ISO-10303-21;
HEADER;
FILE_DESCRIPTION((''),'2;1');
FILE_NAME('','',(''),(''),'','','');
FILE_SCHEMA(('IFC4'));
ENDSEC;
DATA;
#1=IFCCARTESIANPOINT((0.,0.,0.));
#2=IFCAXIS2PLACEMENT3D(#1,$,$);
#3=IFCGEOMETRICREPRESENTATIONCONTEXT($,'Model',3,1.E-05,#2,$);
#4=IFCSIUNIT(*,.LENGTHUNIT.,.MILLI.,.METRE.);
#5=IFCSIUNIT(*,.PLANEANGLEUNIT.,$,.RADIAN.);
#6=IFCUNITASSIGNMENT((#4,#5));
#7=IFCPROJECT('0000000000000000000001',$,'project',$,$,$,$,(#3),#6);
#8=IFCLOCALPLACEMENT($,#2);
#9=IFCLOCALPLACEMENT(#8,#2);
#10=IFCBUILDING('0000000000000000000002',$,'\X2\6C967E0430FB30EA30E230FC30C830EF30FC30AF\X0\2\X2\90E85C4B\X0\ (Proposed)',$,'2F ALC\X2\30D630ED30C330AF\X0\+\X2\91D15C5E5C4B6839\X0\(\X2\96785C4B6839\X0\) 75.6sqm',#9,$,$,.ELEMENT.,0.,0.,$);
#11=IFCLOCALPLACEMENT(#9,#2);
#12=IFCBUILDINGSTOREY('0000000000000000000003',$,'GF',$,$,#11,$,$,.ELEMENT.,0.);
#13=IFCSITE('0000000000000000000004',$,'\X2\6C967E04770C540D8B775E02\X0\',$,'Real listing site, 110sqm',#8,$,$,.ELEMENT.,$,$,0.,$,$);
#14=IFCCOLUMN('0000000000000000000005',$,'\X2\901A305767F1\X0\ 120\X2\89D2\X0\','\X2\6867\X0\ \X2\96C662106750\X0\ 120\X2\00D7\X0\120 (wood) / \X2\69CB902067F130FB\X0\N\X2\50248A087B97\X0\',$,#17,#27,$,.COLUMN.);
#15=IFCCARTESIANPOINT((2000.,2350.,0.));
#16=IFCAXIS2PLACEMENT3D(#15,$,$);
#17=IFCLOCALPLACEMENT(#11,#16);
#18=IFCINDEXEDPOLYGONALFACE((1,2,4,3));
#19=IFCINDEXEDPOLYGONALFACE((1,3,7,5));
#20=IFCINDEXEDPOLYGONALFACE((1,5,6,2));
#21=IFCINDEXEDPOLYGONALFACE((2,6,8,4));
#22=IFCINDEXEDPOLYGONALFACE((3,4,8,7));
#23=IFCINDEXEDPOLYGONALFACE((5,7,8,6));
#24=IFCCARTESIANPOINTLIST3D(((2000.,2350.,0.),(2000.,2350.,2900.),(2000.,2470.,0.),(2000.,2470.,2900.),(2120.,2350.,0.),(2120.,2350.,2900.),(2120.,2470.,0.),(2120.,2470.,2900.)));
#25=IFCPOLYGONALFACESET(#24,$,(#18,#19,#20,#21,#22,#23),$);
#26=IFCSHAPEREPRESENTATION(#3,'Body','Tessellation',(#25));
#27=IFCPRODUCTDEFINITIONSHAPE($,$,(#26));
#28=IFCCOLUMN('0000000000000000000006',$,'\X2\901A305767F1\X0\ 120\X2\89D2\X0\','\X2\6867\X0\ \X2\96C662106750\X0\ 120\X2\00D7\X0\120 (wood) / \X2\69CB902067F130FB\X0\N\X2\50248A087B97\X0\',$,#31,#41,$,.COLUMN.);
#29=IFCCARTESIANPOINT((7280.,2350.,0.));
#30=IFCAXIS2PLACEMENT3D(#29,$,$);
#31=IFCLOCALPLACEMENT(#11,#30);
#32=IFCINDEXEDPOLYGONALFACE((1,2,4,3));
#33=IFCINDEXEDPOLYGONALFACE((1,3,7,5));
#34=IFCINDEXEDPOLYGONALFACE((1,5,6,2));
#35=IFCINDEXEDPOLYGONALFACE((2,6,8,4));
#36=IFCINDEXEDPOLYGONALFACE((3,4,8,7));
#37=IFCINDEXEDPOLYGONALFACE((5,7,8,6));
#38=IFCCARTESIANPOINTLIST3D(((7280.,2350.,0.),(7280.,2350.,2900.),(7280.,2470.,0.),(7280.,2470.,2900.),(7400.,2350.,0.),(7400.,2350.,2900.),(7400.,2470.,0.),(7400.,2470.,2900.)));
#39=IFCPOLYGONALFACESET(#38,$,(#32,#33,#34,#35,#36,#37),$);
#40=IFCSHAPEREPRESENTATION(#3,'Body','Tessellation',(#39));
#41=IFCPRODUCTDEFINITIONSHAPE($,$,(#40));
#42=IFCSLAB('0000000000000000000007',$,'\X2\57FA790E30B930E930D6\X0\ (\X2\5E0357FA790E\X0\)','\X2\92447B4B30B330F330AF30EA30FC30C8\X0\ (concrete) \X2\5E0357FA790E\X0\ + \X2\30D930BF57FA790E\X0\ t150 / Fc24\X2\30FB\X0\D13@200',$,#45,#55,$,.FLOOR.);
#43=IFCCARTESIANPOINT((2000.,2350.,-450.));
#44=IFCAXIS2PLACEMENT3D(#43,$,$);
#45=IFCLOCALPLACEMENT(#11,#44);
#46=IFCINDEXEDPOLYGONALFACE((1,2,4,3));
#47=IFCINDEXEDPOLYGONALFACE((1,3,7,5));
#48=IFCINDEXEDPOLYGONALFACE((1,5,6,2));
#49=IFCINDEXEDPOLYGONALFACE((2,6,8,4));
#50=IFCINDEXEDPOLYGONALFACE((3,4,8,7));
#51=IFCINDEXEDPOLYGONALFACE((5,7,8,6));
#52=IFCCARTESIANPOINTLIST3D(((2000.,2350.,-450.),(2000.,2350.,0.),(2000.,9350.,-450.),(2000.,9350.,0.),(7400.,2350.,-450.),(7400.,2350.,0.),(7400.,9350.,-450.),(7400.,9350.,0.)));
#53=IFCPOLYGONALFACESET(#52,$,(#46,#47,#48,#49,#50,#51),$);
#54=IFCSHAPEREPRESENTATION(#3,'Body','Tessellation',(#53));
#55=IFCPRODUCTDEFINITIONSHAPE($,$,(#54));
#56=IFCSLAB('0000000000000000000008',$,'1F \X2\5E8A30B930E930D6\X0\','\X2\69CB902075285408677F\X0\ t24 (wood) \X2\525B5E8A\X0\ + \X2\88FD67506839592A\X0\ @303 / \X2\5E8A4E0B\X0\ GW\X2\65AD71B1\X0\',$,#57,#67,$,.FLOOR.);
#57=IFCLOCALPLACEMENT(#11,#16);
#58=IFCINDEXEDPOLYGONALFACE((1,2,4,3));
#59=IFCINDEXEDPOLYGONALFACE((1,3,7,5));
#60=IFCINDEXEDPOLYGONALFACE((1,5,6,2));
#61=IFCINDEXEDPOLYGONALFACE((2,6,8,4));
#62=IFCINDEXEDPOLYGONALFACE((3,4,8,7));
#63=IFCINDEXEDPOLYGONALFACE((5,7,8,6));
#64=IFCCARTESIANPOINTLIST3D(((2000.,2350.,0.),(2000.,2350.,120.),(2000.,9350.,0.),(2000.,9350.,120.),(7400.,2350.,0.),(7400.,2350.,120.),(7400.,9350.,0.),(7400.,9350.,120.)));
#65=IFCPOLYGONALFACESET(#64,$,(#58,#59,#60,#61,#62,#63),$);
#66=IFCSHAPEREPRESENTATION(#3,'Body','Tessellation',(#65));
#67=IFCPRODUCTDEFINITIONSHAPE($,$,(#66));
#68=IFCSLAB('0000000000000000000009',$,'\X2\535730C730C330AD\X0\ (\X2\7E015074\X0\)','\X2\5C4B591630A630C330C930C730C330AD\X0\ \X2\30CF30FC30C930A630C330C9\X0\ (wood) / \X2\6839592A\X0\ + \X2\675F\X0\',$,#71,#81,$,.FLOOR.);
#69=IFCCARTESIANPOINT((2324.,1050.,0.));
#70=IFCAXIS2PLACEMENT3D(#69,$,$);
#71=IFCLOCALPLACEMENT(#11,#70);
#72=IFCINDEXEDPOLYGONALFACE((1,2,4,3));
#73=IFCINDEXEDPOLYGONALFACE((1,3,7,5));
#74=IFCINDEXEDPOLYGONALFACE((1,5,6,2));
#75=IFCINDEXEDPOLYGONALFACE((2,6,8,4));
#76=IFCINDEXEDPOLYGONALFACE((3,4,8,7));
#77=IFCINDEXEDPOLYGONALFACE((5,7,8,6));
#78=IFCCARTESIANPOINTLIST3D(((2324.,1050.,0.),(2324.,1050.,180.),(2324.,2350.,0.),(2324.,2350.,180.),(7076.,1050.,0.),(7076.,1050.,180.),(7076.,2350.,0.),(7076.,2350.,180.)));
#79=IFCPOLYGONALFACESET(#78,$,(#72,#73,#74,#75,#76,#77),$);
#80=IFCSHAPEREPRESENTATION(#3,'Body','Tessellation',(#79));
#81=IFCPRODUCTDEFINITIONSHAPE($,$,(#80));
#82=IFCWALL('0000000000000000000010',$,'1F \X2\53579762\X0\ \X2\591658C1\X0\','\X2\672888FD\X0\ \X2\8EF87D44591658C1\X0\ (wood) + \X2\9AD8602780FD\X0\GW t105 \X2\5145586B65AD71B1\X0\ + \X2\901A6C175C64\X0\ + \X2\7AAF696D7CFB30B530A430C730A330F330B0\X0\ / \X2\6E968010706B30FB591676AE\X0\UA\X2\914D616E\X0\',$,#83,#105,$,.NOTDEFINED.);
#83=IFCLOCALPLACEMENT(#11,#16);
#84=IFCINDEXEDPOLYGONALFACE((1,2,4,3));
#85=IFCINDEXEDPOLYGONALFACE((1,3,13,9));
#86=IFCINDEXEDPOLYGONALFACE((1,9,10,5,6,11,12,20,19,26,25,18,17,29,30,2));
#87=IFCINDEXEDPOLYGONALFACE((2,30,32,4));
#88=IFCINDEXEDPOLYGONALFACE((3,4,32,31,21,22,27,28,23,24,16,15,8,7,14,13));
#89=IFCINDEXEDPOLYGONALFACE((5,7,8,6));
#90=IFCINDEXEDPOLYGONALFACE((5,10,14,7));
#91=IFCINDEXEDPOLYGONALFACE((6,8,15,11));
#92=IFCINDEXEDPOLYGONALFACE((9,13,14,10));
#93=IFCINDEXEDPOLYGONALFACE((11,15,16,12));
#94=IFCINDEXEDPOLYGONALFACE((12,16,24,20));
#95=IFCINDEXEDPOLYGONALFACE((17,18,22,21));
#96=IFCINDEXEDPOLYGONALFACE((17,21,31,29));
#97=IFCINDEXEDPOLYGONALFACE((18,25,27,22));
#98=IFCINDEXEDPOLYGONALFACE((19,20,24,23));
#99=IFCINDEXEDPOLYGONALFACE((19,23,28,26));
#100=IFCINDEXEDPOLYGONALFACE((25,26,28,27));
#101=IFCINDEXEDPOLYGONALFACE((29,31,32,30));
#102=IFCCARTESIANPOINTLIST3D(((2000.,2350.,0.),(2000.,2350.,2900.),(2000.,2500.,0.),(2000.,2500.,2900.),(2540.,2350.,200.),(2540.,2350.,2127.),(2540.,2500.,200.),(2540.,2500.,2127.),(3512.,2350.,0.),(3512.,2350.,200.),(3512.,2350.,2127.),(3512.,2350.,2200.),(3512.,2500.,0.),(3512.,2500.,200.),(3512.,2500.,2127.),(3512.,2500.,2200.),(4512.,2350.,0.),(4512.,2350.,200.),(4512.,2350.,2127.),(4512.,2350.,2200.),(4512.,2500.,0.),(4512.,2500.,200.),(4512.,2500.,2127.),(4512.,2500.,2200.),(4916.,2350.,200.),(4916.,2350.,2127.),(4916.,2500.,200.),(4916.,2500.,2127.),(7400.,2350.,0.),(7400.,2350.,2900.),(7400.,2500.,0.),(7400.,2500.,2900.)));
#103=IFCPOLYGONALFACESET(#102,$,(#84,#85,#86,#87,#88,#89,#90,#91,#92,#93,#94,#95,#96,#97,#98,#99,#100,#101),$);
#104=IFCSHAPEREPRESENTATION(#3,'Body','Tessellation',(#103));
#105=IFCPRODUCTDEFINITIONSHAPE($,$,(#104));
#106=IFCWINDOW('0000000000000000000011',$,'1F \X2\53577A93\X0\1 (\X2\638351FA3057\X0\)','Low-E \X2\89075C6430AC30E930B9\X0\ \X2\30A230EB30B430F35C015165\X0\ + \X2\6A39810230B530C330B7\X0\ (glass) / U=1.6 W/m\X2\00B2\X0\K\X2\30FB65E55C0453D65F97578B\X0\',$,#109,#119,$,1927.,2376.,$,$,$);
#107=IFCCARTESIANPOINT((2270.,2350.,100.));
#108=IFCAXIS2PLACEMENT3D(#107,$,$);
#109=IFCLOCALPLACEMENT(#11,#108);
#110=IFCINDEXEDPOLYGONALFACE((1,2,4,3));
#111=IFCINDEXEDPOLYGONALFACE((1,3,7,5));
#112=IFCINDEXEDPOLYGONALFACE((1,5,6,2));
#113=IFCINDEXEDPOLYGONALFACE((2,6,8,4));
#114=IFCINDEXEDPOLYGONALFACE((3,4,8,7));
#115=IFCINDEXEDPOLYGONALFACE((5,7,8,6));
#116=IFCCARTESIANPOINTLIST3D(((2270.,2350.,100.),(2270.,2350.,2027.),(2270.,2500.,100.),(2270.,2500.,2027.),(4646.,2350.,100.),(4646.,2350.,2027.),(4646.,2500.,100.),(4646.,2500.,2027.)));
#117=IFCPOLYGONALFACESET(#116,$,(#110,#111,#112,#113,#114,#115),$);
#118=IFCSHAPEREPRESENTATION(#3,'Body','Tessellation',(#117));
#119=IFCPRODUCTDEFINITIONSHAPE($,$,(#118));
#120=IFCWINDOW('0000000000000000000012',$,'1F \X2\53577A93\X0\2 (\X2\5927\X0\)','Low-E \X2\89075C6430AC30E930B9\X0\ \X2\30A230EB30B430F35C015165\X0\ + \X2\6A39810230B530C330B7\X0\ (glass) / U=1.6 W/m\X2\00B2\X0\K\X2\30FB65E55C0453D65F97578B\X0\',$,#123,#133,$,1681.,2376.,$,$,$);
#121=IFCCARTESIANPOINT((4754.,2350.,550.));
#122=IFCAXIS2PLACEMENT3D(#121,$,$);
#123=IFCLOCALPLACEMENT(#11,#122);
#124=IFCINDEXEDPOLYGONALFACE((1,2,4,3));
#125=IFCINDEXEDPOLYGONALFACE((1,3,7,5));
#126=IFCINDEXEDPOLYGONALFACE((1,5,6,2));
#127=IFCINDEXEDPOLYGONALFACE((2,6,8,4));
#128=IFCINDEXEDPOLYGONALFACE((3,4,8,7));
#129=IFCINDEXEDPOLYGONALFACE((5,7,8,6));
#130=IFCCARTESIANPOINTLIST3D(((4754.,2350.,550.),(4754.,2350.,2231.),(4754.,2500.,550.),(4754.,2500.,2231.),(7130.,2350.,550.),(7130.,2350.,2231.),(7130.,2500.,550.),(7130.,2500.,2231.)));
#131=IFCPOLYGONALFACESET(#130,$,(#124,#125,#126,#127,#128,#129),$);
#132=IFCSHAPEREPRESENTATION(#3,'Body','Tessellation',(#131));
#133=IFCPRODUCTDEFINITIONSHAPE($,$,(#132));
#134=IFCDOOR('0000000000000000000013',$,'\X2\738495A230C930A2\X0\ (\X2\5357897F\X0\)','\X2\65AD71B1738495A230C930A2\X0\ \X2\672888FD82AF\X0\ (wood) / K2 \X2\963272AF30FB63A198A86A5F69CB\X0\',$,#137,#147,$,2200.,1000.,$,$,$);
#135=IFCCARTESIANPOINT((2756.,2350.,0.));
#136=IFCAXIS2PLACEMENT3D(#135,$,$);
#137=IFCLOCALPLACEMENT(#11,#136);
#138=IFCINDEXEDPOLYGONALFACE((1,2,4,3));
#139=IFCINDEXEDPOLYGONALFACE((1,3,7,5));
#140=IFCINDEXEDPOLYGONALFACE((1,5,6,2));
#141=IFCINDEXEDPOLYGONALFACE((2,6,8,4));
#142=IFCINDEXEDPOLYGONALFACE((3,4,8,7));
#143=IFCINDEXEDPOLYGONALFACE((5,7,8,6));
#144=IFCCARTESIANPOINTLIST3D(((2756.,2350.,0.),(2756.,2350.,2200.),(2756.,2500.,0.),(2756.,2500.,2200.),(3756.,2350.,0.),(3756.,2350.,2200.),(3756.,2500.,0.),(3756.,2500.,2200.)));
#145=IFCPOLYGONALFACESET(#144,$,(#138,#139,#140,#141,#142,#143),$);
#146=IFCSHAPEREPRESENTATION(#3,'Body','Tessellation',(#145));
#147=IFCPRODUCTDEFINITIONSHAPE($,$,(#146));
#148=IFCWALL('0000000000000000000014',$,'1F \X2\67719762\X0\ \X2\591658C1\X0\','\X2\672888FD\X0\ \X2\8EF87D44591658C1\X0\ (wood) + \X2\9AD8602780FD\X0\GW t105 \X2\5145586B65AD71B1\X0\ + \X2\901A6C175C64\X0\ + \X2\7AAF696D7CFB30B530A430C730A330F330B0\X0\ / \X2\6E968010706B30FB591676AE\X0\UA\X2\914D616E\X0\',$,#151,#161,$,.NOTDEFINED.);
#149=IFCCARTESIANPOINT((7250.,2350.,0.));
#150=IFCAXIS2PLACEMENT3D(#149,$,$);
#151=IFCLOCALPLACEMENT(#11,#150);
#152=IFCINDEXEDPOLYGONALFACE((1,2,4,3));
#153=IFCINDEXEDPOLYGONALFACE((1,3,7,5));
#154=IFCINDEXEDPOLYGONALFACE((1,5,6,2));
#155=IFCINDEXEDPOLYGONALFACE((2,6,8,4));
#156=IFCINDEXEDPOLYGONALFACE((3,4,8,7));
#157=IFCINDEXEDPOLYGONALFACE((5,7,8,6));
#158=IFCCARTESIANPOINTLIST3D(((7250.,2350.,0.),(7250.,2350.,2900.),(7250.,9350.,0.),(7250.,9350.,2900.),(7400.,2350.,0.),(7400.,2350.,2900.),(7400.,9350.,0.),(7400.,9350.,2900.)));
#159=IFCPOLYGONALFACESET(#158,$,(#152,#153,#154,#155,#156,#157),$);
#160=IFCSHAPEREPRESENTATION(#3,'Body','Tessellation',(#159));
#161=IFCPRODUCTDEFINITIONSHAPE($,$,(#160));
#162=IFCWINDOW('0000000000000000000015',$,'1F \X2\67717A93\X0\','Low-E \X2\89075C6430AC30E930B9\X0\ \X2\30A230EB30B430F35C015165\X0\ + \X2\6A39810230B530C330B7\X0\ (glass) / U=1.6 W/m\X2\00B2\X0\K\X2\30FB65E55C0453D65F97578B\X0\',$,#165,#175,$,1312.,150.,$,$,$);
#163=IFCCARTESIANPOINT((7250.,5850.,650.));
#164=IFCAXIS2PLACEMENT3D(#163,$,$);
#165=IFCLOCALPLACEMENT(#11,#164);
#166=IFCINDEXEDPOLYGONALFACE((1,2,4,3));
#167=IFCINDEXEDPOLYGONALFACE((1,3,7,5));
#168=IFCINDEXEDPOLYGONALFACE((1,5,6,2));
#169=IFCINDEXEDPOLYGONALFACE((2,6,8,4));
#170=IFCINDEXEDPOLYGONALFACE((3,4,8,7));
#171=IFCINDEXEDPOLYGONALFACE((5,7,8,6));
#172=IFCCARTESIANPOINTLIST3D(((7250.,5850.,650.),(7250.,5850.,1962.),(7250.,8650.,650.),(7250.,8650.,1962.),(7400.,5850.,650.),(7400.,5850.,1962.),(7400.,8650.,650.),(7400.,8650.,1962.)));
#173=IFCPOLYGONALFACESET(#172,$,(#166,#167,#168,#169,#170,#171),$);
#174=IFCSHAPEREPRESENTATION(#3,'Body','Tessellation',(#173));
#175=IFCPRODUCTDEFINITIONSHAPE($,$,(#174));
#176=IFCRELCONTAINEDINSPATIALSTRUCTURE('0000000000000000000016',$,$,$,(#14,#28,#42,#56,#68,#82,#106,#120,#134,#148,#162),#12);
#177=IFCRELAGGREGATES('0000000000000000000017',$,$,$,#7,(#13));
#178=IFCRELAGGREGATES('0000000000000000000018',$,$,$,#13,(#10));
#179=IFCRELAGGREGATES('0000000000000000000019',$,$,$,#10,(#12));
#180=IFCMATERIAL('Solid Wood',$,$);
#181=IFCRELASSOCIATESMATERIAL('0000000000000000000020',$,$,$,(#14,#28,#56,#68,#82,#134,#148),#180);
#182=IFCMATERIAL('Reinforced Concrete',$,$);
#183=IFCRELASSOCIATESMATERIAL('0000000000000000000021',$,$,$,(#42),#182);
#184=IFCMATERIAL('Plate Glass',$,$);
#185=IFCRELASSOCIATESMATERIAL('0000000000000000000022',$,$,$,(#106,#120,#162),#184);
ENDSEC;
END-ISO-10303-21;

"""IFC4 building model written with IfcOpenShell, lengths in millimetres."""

from ifc_helpers import new_model, si_unit, frame, frame_2d, origin, place, context, project, spatial, rectangle, extrude, material, element, fill, save


model = new_model("IFC4")

# Units and contexts
model_context = context("Model", 3, precision=1e-05, world=origin())
ifc_project = project(units=[si_unit("LENGTHUNIT", "METRE", prefix="MILLI"), si_unit("PLANEANGLEUNIT", "RADIAN")], contexts=[model_context])

# Site, building, storey
site_placement = place(None, origin())
site = spatial("IfcSite", under=ifc_project, at=site_placement, Name="沖縄県名護市", ObjectType="Real listing site, 110sqm", CompositionType="ELEMENT", RefElevation=0.0)
building_placement = place(site_placement, origin())
building = spatial("IfcBuilding", under=site, at=building_placement, Name="沖縄・リモートワーク2部屋 (Proposed)", ObjectType="2F ALCブロック+金属屋根(陸屋根) 75.6sqm", CompositionType="ELEMENT", ElevationOfRefHeight=0.0, ElevationOfTerrain=0.0)
storey_placement = place(building_placement, origin())
storey = spatial("IfcBuildingStorey", under=building, at=storey_placement, Name="GF", CompositionType="ELEMENT", Elevation=0.0)

# Columns
ifc_material_1 = material(Name="Solid Wood")
column_1_placement = place(storey_placement, frame((2000.0, 2350.0, 0.0)))
element("IfcColumn", 1, at=column_1_placement, inside=storey, material=ifc_material_1, Name="通し柱 120角", Description="桧 集成材 120×120 (wood) / 構造柱・N値計算", PredefinedType="COLUMN", context=model_context, shape_type="SweptSolid", body=[
    extrude(rectangle(XDim=120.0, YDim=120.0, at=frame_2d((60.0, 60.0))), frame((2000.0, 2350.0, 0.0)), (0.0, 0.0, 1.0), 2900.0),
])
column_2_placement = place(storey_placement, frame((7280.0, 2350.0, 0.0)))
element("IfcColumn", 2, at=column_2_placement, inside=storey, material=ifc_material_1, Name="通し柱 120角", Description="桧 集成材 120×120 (wood) / 構造柱・N値計算", PredefinedType="COLUMN", context=model_context, shape_type="SweptSolid", body=[
    extrude(rectangle(XDim=120.0, YDim=120.0, at=frame_2d((60.0, 60.0))), frame((7280.0, 2350.0, 0.0)), (0.0, 0.0, 1.0), 2900.0),
])

# Slabs
ifc_material_2 = material(Name="Reinforced Concrete")
slab_1_placement = place(storey_placement, frame((2000.0, 2350.0, -450.0)))
element("IfcSlab", 3, at=slab_1_placement, inside=storey, material=ifc_material_2, Name="基礎スラブ (布基礎)", Description="鉄筋コンクリート (concrete) 布基礎 + ベタ基礎 t150 / Fc24・D13@200", PredefinedType="FLOOR", context=model_context, shape_type="SweptSolid", body=[
    extrude(rectangle(XDim=5400.0, YDim=7000.0, at=frame_2d((2700.0, 3500.0))), frame((2000.0, 2350.0, -450.0)), (0.0, 0.0, 1.0), 450.0),
])
slab_2_placement = place(storey_placement, frame((2000.0, 2350.0, 0.0)))
element("IfcSlab", 4, at=slab_2_placement, inside=storey, material=ifc_material_1, Name="1F 床スラブ", Description="構造用合板 t24 (wood) 剛床 + 製材根太 @303 / 床下 GW断熱", PredefinedType="FLOOR", context=model_context, shape_type="SweptSolid", body=[
    extrude(rectangle(XDim=5400.0, YDim=7000.0, at=frame_2d((2700.0, 3500.0))), frame((2000.0, 2350.0, 0.0)), (0.0, 0.0, 1.0), 120.0),
])
slab_3_placement = place(storey_placement, frame((2324.0, 1050.0, 0.0)))
element("IfcSlab", 5, at=slab_3_placement, inside=storey, material=ifc_material_1, Name="南デッキ (縁側)", Description="屋外ウッドデッキ ハードウッド (wood) / 根太 + 束", PredefinedType="FLOOR", context=model_context, shape_type="SweptSolid", body=[
    extrude(rectangle(XDim=4752.0, YDim=1300.0, at=frame_2d((2376.0, 650.0))), frame((2324.0, 1050.0, 0.0)), (0.0, 0.0, 1.0), 180.0),
])

# Wall, openings, windows, door
wall_1_placement = place(storey_placement, frame((2000.0, 2350.0, 0.0)))
wall_1 = element("IfcWall", 6, at=wall_1_placement, inside=storey, material=ifc_material_1, Name="1F 南面 外壁", Description="木製 軸組外壁 (wood) + 高性能GW t105 充填断熱 + 通気層 + 窯業系サイディング / 準耐火・外皮UA配慮", PredefinedType="NOTDEFINED", context=model_context, shape_type="SweptSolid", body=[
    extrude(rectangle(XDim=5400.0, YDim=150.0, at=frame_2d((2700.0, 75.0))), frame((2000.0, 2350.0, 0.0)), (0.0, 0.0, 1.0), 2900.0),
])
opening_1_placement = place(storey_placement, frame((2270.0, 2350.0, 100.0)))
opening_1 = element("IfcOpeningElement", 7, at=opening_1_placement, cuts=wall_1, PredefinedType="NOTDEFINED", context=model_context, shape_type="SweptSolid", body=[
    extrude(rectangle(XDim=2376.0, YDim=150.0, at=frame_2d((1188.0, 75.0))), frame((2270.0, 2350.0, 100.0)), (0.0, 0.0, 1.0), 1927.0),
])
opening_2_placement = place(storey_placement, frame((4754.0, 2350.0, 550.0)))
opening_2 = element("IfcOpeningElement", 8, at=opening_2_placement, cuts=wall_1, PredefinedType="NOTDEFINED", context=model_context, shape_type="SweptSolid", body=[
    extrude(rectangle(XDim=2376.0, YDim=150.0, at=frame_2d((1188.0, 75.0))), frame((4754.0, 2350.0, 550.0)), (0.0, 0.0, 1.0), 1681.0),
])
opening_3_placement = place(storey_placement, frame((2756.0, 2350.0, 0.0)))
opening_3 = element("IfcOpeningElement", 9, at=opening_3_placement, cuts=wall_1, PredefinedType="NOTDEFINED", context=model_context, shape_type="SweptSolid", body=[
    extrude(rectangle(XDim=1000.0, YDim=150.0, at=frame_2d((500.0, 75.0))), frame((2756.0, 2350.0, 0.0)), (0.0, 0.0, 1.0), 2200.0),
])
ifc_material_3 = material(Name="Plate Glass")
window_1_placement = place(storey_placement, frame((2270.0, 2350.0, 100.0)))
window_1 = element("IfcWindow", 10, at=window_1_placement, inside=storey, material=ifc_material_3, Name="1F 南窓1 (掃出し)", Description="Low-E 複層ガラス アルゴン封入 + 樹脂サッシ (glass) / U=1.6 W/m²K・日射取得型", OverallHeight=1927.0, OverallWidth=2376.0, context=model_context, shape_type="SweptSolid", body=[
    extrude(rectangle(XDim=2376.0, YDim=150.0, at=frame_2d((1188.0, 75.0))), frame((2270.0, 2350.0, 100.0)), (0.0, 0.0, 1.0), 1927.0),
])
fill(opening_1, window_1)
window_2_placement = place(storey_placement, frame((4754.0, 2350.0, 550.0)))
window_2 = element("IfcWindow", 11, at=window_2_placement, inside=storey, material=ifc_material_3, Name="1F 南窓2 (大)", Description="Low-E 複層ガラス アルゴン封入 + 樹脂サッシ (glass) / U=1.6 W/m²K・日射取得型", OverallHeight=1681.0, OverallWidth=2376.0, context=model_context, shape_type="SweptSolid", body=[
    extrude(rectangle(XDim=2376.0, YDim=150.0, at=frame_2d((1188.0, 75.0))), frame((4754.0, 2350.0, 550.0)), (0.0, 0.0, 1.0), 1681.0),
])
fill(opening_2, window_2)
door_placement = place(storey_placement, frame((2756.0, 2350.0, 0.0)))
door = element("IfcDoor", 12, at=door_placement, inside=storey, material=ifc_material_1, Name="玄関ドア (南西)", Description="断熱玄関ドア 木製芯 (wood) / K2 防犯・採風機構", OverallHeight=2200.0, OverallWidth=1000.0, context=model_context, shape_type="SweptSolid", body=[
    extrude(rectangle(XDim=1000.0, YDim=150.0, at=frame_2d((500.0, 75.0))), frame((2756.0, 2350.0, 0.0)), (0.0, 0.0, 1.0), 2200.0),
])
fill(opening_3, door)

# Wall, opening, window
wall_2_placement = place(storey_placement, frame((7250.0, 2350.0, 0.0)))
wall_2 = element("IfcWall", 13, at=wall_2_placement, inside=storey, material=ifc_material_1, Name="1F 東面 外壁", Description="木製 軸組外壁 (wood) + 高性能GW t105 充填断熱 + 通気層 + 窯業系サイディング / 準耐火・外皮UA配慮", PredefinedType="NOTDEFINED", context=model_context, shape_type="SweptSolid", body=[
    extrude(rectangle(XDim=150.0, YDim=7000.0, at=frame_2d((75.0, 3500.0))), frame((7250.0, 2350.0, 0.0)), (0.0, 0.0, 1.0), 2900.0),
])
opening_4_placement = place(storey_placement, frame((7250.0, 5850.0, 650.0)))
opening_4 = element("IfcOpeningElement", 14, at=opening_4_placement, cuts=wall_2, PredefinedType="NOTDEFINED", context=model_context, shape_type="SweptSolid", body=[
    extrude(rectangle(XDim=150.0, YDim=2800.0, at=frame_2d((75.0, 1400.0))), frame((7250.0, 5850.0, 650.0)), (0.0, 0.0, 1.0), 1312.0),
])
window_3_placement = place(storey_placement, frame((7250.0, 5850.0, 650.0)))
window_3 = element("IfcWindow", 15, at=window_3_placement, inside=storey, material=ifc_material_3, Name="1F 東窓", Description="Low-E 複層ガラス アルゴン封入 + 樹脂サッシ (glass) / U=1.6 W/m²K・日射取得型", OverallHeight=1312.0, OverallWidth=150.0, context=model_context, shape_type="SweptSolid", body=[
    extrude(rectangle(XDim=150.0, YDim=2800.0, at=frame_2d((75.0, 1400.0))), frame((7250.0, 5850.0, 650.0)), (0.0, 0.0, 1.0), 1312.0),
])
fill(opening_4, window_3)

save(model, "model.ifc")
